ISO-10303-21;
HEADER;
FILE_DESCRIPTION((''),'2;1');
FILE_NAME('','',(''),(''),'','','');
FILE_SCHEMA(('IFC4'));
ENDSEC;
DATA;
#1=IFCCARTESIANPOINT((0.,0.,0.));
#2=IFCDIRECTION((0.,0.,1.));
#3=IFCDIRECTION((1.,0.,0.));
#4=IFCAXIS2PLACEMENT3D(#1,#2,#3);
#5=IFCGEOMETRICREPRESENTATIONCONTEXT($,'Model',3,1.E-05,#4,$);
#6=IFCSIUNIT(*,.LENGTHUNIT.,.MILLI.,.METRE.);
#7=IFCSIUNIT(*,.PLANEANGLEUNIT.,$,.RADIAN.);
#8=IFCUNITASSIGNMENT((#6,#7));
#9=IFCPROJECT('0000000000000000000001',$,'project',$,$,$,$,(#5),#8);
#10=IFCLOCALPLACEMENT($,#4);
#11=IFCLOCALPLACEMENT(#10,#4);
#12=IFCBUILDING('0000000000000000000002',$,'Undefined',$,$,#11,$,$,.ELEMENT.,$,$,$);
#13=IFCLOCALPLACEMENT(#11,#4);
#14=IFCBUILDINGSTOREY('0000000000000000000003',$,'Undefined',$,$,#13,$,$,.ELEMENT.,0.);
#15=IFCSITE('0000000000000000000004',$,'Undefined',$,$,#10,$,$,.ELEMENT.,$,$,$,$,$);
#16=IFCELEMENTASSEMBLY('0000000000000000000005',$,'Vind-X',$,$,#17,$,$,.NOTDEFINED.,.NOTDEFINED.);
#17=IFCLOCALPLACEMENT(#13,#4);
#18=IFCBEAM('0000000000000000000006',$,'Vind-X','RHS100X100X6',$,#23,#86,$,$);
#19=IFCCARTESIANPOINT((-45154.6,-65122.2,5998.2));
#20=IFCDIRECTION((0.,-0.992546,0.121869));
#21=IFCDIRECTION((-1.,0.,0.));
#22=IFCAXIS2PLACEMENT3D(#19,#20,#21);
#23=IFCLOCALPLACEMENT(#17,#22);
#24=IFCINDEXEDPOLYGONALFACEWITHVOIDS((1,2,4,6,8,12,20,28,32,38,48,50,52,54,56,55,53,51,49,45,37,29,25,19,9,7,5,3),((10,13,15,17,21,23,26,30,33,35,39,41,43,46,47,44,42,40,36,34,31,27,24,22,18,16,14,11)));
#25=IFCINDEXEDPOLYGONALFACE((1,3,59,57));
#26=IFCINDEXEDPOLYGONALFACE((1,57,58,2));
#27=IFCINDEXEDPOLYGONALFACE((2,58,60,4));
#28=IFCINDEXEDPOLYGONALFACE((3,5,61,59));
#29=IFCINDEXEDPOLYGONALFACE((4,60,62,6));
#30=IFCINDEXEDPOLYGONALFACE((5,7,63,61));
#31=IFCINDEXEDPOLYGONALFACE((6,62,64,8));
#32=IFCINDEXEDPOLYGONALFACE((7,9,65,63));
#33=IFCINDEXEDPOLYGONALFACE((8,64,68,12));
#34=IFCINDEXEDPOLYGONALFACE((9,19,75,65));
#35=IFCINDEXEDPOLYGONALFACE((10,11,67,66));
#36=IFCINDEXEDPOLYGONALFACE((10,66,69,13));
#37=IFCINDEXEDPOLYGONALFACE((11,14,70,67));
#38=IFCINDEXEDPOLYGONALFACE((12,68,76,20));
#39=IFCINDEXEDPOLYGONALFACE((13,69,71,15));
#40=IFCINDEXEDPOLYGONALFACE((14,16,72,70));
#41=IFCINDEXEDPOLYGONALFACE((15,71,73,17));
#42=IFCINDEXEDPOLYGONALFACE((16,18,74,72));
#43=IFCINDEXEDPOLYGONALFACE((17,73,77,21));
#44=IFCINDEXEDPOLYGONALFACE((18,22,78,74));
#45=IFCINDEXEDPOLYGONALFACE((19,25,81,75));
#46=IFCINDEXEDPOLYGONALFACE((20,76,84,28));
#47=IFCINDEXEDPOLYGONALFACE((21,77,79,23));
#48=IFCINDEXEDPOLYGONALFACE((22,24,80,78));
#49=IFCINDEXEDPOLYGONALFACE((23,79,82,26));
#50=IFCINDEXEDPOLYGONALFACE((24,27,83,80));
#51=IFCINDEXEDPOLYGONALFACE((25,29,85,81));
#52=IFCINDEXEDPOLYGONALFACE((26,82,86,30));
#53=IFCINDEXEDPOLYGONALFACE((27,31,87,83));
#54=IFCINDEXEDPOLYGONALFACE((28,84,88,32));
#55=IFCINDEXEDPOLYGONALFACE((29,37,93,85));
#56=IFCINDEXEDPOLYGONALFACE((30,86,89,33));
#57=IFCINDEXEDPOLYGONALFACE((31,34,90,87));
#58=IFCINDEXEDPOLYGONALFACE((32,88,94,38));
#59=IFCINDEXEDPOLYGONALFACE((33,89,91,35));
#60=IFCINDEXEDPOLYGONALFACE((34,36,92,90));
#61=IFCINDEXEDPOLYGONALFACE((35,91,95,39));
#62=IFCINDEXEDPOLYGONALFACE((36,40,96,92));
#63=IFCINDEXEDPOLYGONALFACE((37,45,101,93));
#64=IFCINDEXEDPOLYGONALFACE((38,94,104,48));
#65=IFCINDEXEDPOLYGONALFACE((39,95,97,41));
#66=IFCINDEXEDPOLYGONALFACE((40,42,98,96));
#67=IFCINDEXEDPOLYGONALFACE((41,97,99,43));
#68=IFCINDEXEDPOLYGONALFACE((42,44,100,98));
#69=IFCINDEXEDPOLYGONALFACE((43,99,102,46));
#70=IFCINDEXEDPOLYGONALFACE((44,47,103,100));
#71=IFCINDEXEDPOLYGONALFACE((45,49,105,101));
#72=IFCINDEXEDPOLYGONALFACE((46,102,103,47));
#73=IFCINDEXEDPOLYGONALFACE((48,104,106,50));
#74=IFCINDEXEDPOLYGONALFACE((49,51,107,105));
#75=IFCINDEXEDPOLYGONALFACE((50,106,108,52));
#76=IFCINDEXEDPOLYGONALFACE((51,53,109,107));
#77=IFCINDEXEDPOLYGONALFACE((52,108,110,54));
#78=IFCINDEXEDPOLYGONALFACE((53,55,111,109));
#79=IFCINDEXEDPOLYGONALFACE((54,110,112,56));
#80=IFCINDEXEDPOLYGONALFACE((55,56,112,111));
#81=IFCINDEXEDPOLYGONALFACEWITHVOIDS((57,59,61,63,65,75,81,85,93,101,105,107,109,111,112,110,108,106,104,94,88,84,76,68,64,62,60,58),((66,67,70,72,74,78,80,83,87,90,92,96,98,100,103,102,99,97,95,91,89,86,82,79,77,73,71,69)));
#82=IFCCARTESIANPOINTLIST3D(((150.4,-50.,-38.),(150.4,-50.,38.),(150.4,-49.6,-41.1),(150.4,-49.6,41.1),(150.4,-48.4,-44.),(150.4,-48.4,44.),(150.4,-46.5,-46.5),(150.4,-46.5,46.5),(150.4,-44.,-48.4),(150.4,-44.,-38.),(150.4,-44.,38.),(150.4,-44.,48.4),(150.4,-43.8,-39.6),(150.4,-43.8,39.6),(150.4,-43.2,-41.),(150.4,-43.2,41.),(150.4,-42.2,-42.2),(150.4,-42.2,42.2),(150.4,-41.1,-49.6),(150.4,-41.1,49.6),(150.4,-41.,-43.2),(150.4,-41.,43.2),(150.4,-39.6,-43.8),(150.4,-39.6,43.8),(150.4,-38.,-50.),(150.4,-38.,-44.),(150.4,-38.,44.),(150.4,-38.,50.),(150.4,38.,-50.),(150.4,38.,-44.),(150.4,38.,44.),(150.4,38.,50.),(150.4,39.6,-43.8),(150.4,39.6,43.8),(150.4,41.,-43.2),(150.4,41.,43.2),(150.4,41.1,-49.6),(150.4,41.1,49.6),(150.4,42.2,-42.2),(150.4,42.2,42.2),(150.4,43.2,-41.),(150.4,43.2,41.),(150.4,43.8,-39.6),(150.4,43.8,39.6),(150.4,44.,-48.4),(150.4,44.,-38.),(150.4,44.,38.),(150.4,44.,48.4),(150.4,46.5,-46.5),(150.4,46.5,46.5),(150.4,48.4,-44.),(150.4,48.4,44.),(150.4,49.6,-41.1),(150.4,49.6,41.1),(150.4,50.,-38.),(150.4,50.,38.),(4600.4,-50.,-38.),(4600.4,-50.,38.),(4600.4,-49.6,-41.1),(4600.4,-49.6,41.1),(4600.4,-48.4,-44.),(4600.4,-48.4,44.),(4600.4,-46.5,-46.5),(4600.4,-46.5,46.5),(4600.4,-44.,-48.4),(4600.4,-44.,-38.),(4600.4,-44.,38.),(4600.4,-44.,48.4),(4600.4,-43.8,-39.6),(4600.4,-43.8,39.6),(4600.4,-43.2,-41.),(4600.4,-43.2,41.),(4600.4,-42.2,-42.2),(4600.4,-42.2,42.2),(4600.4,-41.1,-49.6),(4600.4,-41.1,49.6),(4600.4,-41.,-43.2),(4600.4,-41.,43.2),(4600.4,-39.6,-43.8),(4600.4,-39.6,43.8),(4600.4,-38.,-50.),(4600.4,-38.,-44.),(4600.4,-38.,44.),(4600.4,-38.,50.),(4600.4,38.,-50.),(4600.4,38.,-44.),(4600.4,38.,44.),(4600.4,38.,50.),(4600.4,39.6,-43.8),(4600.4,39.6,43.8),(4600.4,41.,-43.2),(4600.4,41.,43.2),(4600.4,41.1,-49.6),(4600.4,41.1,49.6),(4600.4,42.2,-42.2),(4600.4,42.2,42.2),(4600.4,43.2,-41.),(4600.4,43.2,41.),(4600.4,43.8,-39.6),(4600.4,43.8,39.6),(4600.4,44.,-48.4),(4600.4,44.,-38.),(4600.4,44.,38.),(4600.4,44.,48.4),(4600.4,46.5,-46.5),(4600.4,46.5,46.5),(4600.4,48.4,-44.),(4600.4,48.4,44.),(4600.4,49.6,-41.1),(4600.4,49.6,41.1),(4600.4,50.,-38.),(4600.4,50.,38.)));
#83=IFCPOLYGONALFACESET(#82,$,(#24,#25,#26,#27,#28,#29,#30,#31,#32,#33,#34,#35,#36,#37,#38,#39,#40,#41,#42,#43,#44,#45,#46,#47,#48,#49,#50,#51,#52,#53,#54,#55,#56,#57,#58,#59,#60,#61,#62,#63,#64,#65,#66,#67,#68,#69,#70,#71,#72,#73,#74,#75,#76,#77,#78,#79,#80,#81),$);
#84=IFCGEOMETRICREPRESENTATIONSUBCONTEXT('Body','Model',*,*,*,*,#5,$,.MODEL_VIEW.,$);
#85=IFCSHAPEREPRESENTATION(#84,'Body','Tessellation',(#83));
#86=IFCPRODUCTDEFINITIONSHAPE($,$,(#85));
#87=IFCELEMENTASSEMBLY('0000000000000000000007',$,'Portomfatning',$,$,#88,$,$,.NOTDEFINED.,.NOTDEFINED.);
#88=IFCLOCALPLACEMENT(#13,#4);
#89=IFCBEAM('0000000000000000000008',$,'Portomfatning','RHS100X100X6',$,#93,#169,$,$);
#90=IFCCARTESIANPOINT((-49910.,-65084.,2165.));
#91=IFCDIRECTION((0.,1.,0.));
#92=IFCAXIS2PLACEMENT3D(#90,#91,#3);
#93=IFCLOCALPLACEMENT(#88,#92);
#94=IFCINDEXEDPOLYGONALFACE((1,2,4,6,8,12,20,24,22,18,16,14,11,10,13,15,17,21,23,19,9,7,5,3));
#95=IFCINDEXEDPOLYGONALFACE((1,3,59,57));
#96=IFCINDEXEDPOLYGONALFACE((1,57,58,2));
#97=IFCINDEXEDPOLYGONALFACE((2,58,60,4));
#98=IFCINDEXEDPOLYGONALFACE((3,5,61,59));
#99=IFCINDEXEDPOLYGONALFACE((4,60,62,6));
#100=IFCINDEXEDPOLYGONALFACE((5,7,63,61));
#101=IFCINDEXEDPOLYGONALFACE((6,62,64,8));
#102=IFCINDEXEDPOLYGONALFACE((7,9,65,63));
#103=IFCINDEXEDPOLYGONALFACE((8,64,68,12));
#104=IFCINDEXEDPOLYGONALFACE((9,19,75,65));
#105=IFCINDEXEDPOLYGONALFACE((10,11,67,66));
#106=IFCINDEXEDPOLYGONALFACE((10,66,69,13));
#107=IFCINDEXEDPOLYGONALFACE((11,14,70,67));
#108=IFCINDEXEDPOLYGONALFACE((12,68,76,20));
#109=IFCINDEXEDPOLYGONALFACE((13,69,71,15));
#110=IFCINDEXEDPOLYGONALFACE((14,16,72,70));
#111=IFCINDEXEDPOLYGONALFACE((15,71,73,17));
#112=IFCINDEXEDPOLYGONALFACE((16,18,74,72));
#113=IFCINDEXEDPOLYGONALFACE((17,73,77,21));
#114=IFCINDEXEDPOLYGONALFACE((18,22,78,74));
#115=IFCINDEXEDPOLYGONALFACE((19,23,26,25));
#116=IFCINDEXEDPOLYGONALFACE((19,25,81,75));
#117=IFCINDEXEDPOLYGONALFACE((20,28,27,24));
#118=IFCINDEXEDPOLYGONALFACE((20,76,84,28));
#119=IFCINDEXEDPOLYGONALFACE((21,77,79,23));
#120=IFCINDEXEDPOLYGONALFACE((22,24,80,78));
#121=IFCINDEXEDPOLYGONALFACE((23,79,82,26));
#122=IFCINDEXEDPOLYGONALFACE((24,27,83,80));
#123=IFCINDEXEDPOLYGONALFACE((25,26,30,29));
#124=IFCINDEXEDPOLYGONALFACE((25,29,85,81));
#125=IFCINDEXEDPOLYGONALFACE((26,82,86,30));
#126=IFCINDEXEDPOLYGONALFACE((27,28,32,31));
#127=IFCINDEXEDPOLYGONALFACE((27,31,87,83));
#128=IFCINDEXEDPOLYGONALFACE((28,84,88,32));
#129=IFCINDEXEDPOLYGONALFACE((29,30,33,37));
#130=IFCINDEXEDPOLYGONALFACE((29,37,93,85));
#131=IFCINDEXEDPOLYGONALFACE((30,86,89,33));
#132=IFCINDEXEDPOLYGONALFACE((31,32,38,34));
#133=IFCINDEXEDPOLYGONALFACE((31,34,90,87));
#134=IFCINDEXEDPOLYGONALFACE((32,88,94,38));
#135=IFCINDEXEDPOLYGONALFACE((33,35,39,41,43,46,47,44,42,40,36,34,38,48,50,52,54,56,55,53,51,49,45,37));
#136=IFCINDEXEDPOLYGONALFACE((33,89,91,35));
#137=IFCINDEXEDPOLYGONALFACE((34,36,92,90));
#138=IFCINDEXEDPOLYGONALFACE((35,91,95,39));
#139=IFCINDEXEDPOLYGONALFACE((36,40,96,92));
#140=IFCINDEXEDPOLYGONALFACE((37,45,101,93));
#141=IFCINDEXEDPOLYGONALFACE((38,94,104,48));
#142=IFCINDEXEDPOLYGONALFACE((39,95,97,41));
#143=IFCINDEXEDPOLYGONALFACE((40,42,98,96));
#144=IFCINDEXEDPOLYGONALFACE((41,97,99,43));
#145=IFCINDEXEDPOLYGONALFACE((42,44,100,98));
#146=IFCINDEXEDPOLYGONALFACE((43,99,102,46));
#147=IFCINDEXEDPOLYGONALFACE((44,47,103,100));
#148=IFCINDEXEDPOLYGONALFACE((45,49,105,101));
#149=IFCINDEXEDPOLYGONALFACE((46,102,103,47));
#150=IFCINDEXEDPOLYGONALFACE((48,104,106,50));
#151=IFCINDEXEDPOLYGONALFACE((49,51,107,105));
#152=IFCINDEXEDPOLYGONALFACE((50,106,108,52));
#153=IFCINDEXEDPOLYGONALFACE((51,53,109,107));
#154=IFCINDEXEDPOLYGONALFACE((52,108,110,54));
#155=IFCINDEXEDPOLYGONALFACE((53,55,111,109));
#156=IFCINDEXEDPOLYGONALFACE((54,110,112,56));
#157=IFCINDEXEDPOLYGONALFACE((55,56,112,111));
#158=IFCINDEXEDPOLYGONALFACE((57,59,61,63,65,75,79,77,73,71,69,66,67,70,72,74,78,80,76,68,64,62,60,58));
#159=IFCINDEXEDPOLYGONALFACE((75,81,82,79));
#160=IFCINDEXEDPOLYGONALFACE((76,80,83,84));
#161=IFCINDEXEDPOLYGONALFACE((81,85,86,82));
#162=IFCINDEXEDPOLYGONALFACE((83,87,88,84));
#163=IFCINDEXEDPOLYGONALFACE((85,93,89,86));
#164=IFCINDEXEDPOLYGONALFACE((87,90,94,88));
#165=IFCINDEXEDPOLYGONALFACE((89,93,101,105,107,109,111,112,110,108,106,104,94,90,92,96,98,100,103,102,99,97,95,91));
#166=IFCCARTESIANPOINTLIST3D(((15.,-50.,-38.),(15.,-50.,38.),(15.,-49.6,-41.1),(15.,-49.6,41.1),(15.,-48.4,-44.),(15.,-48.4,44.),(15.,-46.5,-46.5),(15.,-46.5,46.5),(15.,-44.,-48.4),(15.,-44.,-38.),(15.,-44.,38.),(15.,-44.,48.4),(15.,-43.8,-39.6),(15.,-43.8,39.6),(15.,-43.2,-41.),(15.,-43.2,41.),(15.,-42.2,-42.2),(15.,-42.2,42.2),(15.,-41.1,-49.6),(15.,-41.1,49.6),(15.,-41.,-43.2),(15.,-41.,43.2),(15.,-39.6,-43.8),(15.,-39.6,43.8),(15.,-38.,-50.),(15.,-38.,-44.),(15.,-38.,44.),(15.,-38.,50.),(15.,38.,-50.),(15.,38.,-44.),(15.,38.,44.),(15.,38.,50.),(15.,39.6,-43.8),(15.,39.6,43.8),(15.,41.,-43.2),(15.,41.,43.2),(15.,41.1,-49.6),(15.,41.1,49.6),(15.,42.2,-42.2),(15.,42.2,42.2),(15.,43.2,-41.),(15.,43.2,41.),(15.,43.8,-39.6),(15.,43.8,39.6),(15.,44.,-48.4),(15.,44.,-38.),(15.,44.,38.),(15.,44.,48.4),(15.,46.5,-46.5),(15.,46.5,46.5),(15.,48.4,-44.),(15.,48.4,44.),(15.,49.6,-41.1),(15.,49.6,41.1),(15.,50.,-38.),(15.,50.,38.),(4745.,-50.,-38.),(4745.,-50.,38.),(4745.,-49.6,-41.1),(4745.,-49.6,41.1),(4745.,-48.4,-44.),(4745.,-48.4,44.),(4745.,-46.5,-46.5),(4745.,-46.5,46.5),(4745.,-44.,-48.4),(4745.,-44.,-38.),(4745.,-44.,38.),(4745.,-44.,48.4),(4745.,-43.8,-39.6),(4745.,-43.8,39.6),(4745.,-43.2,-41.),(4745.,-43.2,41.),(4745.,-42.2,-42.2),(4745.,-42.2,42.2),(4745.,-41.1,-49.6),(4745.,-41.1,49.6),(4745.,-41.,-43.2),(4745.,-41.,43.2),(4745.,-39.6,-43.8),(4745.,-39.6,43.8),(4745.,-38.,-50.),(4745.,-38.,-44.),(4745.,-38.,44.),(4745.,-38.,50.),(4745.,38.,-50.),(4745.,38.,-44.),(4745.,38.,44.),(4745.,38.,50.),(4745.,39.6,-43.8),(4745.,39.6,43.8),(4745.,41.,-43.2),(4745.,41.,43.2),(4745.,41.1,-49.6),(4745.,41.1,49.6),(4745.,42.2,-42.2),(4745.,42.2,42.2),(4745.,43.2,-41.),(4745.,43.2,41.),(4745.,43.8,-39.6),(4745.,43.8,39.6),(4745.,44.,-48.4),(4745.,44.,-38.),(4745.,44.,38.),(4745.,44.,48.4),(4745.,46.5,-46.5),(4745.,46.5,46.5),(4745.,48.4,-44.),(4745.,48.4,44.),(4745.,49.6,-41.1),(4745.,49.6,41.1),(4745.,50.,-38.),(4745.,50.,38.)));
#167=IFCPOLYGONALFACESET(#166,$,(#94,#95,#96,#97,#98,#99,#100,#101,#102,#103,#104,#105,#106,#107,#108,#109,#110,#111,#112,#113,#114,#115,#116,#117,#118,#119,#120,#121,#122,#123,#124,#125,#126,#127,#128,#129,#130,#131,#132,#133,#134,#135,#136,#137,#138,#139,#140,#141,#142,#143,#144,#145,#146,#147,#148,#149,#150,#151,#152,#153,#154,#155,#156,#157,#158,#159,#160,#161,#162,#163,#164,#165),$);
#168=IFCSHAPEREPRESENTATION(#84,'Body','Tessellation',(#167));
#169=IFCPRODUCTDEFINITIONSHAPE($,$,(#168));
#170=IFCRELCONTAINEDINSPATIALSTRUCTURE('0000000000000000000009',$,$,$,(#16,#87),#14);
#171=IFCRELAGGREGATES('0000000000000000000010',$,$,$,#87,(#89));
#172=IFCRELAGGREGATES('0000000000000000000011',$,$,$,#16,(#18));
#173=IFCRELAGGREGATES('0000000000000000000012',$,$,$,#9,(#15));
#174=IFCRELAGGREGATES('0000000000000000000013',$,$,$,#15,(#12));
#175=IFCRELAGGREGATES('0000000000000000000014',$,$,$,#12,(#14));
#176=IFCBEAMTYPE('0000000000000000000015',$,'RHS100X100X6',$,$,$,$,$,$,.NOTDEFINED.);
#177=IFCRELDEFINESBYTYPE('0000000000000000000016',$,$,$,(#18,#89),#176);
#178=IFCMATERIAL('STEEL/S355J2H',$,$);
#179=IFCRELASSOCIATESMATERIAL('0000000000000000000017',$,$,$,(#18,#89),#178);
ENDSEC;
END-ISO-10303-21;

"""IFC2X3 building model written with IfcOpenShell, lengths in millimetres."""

from ifc_helpers import new_model, si_unit, frame, origin_with_axes, origin_2d_with_axis, place, context, subcontext, project, spatial, hollow_rectangle, extrude, clip, halfspace, material, type_object, element, aggregate, save


model = new_model("IFC2X3")

# Units and contexts
model_context = context("Model", 3, precision=1e-05, world=origin_with_axes())
body_context = subcontext(model_context, "Body", "Model", "MODEL_VIEW")
ifc_project = project(units=[si_unit("LENGTHUNIT", "METRE", prefix="MILLI"), si_unit("PLANEANGLEUNIT", "RADIAN")], contexts=[model_context])

# Site, building, storey
site_placement = place(None, origin_with_axes())
site = spatial("IfcSite", under=ifc_project, at=site_placement, Name="Undefined", CompositionType="ELEMENT")
building_placement = place(site_placement, origin_with_axes())
building = spatial("IfcBuilding", under=site, at=building_placement, Name="Undefined", CompositionType="ELEMENT")
storey_placement = place(building_placement, origin_with_axes())
storey = spatial("IfcBuildingStorey", under=building, at=storey_placement, Name="Undefined", CompositionType="ELEMENT", Elevation=0.0)

# Element assemblies, beams
assembly_1_placement = place(storey_placement, origin_with_axes())
assembly_1 = element("IfcElementAssembly", 1, at=assembly_1_placement, inside=storey, Name="Vind-X", AssemblyPlace="NOTDEFINED", PredefinedType="NOTDEFINED")
ifc_material_1 = material(Name="STEEL/S355J2H")
beam_type = type_object("IfcBeamType", Name="RHS100X100X6", PredefinedType="NOTDEFINED")
beam_1_placement = place(assembly_1_placement, frame((-45154.6, -65122.2, 5998.2), z_axis=(0.0, -0.992546, 0.121869), x_axis=(-1.0, 0.0, 0.0)))
beam_1 = element("IfcBeam", 2, at=beam_1_placement, type_object=beam_type, material=ifc_material_1, Name="Vind-X", Description="RHS100X100X6", context=body_context, shape_type="Clipping", body=[
    clip(clip(extrude(hollow_rectangle(XDim=100.0, YDim=100.0, WallThickness=6.0, InnerFilletRadius=6.0, OuterFilletRadius=12.0, at=origin_2d_with_axis()), frame((4690.0, 0.0, 0.0), z_axis=(-1.0, 0.0, 0.0), x_axis=(0.0, -1.0, 0.0)), (0.0, 0.0, 1.0), 4690.0), halfspace(frame((4600.4, 22.5, 0.0), z_axis=(-1.0, 0.0, 0.0), x_axis=(0.0, 0.0, 1.0)), True)), halfspace(frame((150.4, 22.5, 0.0), z_axis=(1.0, 0.0, 0.0), x_axis=(0.0, 0.0, -1.0)), True)),
])
assembly_2_placement = place(storey_placement, origin_with_axes())
assembly_2 = element("IfcElementAssembly", 3, at=assembly_2_placement, inside=storey, Name="Portomfatning", AssemblyPlace="NOTDEFINED", PredefinedType="NOTDEFINED")
beam_2_placement = place(assembly_2_placement, frame((-49910.0, -65084.0, 2165.0), z_axis=(0.0, 1.0, 0.0), x_axis=(1.0, 0.0, 0.0)))
beam_2 = element("IfcBeam", 4, at=beam_2_placement, type_object=beam_type, material=ifc_material_1, Name="Portomfatning", Description="RHS100X100X6", context=body_context, shape_type="Clipping", body=[
    clip(clip(extrude(hollow_rectangle(XDim=100.0, YDim=100.0, WallThickness=6.0, InnerFilletRadius=6.0, OuterFilletRadius=12.0, at=origin_2d_with_axis()), frame((4760.0, 0.0, 0.0), z_axis=(-1.0, 0.0, 0.0), x_axis=(0.0, -1.0, 0.0)), (0.0, 0.0, 1.0), 4760.0), halfspace(frame((4745.0, -50.0, -50.0), z_axis=(-1.0, 0.0, 0.000185), x_axis=(0.0, 1.0, 0.0)), True)), halfspace(frame((15.0, 50.0, -50.0), z_axis=(1.0, 0.0, 0.000185), x_axis=(0.0, -1.0, 0.0)), True)),
])

aggregate(assembly_2, [beam_2])

aggregate(assembly_1, [beam_1])

save(model, "model.ifc")
